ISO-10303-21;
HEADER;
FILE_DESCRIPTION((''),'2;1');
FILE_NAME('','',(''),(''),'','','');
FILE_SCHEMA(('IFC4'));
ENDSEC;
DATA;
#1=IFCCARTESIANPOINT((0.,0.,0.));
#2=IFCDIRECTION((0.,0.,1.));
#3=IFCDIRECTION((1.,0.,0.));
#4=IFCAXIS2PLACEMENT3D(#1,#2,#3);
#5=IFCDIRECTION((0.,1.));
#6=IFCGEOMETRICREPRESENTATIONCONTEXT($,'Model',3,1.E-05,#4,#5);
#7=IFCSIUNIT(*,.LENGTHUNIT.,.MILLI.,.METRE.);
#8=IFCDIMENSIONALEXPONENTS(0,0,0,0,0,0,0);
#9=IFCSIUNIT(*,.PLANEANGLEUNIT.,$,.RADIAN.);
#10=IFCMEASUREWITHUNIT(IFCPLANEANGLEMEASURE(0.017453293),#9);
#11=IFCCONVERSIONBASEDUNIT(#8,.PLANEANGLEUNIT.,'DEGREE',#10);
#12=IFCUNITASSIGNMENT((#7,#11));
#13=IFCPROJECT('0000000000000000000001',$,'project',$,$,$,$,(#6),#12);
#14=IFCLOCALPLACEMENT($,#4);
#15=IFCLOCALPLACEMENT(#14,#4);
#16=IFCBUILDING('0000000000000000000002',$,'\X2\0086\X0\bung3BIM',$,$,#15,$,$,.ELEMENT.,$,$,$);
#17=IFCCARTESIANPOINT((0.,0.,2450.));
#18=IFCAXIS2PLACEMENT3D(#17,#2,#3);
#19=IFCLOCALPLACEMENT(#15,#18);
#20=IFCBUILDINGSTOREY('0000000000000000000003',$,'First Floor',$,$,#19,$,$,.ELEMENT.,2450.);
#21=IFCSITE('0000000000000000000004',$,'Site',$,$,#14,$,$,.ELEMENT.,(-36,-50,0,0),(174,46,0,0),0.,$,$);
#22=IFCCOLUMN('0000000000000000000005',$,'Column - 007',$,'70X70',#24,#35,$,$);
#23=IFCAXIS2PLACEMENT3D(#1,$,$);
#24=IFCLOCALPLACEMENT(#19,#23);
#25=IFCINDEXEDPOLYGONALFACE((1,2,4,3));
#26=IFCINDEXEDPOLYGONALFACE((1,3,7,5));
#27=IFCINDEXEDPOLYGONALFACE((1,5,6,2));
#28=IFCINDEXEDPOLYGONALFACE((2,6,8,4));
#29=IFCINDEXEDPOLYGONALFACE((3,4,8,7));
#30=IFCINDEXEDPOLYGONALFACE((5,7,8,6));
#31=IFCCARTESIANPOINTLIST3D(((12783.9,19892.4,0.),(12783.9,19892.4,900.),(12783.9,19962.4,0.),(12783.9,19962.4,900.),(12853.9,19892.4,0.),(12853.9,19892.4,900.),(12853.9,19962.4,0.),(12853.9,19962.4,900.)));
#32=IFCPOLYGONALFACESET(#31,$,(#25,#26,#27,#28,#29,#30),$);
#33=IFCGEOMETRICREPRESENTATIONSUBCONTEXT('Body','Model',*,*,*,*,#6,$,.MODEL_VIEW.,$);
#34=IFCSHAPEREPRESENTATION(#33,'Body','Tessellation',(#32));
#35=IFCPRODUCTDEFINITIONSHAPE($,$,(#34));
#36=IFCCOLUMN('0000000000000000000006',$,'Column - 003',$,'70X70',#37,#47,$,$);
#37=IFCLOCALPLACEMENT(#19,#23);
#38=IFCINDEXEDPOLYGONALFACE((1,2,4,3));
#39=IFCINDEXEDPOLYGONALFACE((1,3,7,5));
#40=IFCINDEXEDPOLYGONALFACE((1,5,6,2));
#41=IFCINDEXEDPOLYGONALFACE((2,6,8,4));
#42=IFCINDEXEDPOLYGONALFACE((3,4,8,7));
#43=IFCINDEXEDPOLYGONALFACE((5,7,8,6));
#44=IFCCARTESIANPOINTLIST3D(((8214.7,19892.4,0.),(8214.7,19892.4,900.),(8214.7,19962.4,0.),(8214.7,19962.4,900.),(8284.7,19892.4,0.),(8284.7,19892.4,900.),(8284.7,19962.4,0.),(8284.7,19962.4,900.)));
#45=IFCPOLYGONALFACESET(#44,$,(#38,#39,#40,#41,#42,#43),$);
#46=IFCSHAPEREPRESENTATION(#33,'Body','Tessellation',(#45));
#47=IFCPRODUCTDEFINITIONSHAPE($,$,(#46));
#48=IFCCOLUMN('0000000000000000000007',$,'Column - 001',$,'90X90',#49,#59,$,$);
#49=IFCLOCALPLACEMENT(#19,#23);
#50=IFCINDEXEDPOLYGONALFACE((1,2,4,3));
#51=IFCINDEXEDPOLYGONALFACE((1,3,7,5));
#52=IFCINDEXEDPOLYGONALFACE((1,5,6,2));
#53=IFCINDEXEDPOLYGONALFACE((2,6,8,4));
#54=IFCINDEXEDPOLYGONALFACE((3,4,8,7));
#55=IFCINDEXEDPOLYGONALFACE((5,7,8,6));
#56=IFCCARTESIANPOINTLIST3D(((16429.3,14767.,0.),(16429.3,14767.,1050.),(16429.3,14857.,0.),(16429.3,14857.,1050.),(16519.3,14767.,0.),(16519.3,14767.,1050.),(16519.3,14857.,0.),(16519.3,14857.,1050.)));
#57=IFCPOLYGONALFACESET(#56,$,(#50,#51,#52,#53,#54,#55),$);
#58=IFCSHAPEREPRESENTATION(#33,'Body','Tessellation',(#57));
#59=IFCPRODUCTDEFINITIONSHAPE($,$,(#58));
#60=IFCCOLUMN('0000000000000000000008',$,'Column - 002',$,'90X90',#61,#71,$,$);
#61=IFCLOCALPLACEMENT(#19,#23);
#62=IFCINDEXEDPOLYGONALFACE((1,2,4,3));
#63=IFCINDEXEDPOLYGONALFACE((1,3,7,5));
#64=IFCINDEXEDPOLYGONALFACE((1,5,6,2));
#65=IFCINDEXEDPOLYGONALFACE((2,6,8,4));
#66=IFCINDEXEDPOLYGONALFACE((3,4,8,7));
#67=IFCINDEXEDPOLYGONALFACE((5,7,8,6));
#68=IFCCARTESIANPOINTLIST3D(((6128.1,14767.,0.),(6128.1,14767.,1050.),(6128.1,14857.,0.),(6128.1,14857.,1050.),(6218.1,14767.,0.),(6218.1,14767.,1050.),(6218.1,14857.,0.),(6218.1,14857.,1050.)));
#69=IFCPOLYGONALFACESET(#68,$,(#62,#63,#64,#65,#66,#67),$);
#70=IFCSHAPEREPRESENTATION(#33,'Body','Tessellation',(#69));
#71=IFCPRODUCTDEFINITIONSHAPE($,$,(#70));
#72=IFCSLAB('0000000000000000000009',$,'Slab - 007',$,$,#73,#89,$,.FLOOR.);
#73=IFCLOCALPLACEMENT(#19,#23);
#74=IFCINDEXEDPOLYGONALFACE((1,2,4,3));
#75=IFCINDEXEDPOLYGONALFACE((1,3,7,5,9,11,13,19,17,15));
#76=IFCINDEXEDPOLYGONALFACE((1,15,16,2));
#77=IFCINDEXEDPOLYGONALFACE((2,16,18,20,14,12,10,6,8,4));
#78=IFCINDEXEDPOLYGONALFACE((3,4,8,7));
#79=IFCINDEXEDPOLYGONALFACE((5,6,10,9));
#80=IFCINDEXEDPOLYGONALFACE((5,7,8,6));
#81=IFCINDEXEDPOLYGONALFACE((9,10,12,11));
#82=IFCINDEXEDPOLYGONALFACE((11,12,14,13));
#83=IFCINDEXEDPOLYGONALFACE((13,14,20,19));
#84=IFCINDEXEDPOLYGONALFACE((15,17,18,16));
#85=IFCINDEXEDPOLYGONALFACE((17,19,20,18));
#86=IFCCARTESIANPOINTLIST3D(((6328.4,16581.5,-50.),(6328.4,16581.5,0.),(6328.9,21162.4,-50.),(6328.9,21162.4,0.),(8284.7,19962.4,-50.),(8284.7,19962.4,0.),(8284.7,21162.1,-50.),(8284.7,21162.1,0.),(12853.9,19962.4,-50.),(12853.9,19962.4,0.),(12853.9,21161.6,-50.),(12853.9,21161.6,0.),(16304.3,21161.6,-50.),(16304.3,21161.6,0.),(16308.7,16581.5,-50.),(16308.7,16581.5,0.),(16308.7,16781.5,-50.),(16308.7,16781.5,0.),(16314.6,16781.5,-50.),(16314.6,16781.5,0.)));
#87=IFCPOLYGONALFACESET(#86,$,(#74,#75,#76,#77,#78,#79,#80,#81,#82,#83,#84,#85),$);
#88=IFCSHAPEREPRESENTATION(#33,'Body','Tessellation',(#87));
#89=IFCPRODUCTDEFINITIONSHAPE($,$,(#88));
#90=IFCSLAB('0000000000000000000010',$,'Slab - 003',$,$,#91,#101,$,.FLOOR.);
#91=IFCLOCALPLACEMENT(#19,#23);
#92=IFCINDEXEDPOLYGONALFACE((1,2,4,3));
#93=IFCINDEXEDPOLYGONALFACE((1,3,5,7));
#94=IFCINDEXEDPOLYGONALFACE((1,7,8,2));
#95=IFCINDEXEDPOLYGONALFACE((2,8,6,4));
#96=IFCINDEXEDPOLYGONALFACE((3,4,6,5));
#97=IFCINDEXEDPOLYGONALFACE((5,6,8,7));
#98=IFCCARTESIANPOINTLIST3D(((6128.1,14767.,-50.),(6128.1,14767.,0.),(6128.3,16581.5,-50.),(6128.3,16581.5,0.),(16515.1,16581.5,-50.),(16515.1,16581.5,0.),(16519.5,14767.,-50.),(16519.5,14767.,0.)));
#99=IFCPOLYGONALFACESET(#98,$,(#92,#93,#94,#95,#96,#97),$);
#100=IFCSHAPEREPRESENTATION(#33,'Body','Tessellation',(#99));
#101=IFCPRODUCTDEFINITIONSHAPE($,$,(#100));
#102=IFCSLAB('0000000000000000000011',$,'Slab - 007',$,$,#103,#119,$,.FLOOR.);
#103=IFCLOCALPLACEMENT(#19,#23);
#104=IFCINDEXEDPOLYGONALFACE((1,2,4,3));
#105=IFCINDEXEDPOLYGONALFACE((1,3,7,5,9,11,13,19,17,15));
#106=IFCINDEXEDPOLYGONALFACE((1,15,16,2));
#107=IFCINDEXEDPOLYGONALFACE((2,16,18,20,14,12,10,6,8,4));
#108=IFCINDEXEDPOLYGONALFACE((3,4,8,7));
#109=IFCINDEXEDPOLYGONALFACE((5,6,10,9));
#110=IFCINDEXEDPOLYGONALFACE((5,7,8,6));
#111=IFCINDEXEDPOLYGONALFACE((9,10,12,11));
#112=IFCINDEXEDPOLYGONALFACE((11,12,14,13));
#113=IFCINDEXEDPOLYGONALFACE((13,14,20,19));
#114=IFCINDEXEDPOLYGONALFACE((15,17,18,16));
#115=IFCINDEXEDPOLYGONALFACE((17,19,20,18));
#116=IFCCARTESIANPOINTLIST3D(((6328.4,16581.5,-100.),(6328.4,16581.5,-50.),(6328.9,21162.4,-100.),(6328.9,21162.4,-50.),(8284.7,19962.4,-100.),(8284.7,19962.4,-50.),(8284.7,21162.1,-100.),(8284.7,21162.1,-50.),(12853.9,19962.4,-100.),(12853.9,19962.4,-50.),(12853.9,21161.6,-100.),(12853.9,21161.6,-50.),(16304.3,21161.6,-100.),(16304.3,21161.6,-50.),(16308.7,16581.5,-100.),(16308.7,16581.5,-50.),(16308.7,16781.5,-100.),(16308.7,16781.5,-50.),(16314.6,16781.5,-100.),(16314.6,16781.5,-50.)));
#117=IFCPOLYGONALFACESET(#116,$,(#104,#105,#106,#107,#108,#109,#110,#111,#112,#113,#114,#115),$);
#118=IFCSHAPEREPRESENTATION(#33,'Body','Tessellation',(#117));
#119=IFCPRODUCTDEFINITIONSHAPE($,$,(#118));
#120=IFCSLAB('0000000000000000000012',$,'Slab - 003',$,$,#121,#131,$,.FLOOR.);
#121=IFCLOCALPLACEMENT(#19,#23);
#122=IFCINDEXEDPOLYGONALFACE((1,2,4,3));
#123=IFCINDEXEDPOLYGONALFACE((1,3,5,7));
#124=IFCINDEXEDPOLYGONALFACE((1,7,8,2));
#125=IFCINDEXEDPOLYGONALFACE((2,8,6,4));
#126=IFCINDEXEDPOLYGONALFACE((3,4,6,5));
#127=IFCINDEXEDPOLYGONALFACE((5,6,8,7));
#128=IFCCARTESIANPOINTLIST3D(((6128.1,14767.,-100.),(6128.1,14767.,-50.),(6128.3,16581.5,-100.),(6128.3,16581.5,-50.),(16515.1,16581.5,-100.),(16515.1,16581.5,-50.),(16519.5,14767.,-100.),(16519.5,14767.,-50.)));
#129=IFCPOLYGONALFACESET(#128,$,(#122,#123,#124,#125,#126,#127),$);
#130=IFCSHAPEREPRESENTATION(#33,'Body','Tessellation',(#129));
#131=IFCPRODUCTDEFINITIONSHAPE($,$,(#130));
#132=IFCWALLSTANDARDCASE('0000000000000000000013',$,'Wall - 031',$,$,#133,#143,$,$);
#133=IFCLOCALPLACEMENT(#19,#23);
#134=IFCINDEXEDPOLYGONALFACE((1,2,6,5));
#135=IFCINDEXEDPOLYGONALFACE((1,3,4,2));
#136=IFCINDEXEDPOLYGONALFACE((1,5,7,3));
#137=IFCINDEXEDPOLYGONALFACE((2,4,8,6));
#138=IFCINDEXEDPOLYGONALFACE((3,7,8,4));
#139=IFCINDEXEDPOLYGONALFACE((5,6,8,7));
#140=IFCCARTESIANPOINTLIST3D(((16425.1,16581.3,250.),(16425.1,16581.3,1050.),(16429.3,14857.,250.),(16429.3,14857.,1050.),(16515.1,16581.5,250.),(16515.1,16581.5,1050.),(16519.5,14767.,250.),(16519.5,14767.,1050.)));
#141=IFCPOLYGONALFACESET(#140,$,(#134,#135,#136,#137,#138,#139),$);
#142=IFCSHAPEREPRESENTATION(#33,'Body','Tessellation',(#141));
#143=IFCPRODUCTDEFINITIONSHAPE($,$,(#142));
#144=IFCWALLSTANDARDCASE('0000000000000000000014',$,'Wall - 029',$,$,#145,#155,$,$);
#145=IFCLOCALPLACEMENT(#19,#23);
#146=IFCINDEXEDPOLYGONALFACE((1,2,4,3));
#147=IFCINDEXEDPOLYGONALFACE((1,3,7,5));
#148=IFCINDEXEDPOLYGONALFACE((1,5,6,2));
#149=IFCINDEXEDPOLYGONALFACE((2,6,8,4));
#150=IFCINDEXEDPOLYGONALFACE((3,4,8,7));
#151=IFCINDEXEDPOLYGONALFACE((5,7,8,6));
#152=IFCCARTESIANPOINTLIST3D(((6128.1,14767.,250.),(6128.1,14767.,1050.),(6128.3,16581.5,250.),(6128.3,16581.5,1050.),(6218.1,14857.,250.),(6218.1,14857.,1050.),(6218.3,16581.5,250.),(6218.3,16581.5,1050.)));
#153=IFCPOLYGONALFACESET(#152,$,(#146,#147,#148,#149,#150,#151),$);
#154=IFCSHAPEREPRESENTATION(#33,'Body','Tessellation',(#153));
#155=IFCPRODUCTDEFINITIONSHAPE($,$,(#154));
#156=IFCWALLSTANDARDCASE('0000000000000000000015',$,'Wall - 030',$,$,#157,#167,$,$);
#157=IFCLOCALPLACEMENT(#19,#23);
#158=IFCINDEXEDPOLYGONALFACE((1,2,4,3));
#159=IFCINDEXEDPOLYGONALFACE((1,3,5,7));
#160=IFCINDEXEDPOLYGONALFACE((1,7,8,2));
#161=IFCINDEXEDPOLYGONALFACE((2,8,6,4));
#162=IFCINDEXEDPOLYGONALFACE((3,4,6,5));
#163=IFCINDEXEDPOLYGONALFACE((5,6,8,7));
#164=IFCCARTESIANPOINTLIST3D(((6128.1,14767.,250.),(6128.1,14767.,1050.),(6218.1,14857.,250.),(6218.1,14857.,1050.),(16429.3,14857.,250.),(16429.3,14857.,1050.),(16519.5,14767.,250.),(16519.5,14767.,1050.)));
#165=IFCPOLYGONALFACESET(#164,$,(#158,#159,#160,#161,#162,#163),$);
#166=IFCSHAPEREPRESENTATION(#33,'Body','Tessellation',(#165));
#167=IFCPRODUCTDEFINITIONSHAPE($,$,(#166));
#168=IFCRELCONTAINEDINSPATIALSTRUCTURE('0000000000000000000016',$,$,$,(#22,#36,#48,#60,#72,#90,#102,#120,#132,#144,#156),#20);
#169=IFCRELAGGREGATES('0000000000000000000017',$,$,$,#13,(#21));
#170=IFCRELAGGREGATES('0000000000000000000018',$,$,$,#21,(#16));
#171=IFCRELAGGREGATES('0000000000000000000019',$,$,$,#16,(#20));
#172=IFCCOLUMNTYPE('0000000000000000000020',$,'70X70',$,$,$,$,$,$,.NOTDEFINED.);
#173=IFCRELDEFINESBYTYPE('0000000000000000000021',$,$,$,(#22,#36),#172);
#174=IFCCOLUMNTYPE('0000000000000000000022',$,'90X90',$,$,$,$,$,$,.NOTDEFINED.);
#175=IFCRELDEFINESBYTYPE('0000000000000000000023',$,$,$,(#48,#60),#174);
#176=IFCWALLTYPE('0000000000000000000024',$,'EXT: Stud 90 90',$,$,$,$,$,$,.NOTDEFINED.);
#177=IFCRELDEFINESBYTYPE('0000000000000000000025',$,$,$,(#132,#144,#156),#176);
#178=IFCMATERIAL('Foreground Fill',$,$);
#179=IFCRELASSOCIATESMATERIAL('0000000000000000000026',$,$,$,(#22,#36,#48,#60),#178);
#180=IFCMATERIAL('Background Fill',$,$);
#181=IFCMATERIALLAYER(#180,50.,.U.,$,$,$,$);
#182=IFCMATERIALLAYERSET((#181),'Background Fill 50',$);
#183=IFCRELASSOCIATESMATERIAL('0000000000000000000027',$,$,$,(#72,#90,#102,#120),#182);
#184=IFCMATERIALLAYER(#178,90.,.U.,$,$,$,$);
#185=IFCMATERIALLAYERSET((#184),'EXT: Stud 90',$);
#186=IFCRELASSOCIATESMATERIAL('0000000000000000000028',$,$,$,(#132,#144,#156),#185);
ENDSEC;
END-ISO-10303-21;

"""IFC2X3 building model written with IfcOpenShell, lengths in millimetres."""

from ifc_helpers import new_model, entity, si_unit, converted_unit, direction, frame, origin_with_axes, origin_2d_with_axis, place, context, subcontext, project, spatial, polyline, rectangle, outline, extrude, material, layer, layer_set, layer_usage, type_object, element, save


model = new_model("IFC2X3")

# Units and contexts
model_context = context("Model", 3, precision=1e-05, world=origin_with_axes(), true_north=direction((0.0, 1.0)))
body_context = subcontext(model_context, "Body", "Model", "MODEL_VIEW")
ifc_project = project(units=[si_unit("LENGTHUNIT", "METRE", prefix="MILLI"), converted_unit("PLANEANGLEUNIT", "DEGREE", entity("IfcPlaneAngleMeasure", 0.017453293), si_unit("PLANEANGLEUNIT", "RADIAN"), dimensions=[0, 0, 0, 0, 0, 0, 0])], contexts=[model_context])

# Site, building, storey
site_placement = place(None, origin_with_axes())
site = spatial("IfcSite", under=ifc_project, at=site_placement, Name="Site", CompositionType="ELEMENT", RefLatitude=(-36, -50, 0, 0), RefLongitude=(174, 46, 0, 0), RefElevation=0.0)
building_placement = place(site_placement, origin_with_axes())
building = spatial("IfcBuilding", under=site, at=building_placement, Name="\u0086bung3BIM", CompositionType="ELEMENT")
storey_placement = place(building_placement, frame((0.0, 0.0, 2450.0), z_axis=(0.0, 0.0, 1.0), x_axis=(1.0, 0.0, 0.0)))
storey = spatial("IfcBuildingStorey", under=building, at=storey_placement, Name="First Floor", CompositionType="ELEMENT", Elevation=2450.0)

# Columns
ifc_material_1 = material(Name="Foreground Fill")
column_type_1 = type_object("IfcColumnType", Name="70X70", PredefinedType="NOTDEFINED")
for number, where, z_axis, x_axis, name in (
    (1, (12818.9, 19927.4, 0.0), (0.0, 0.0, 1.0), (1.0, 0.0, 0.0), "Column - 007"),
    (2, (8249.7, 19927.4, 0.0), (0.0, 0.0, 1.0), (1.0, 0.0, 0.0), "Column - 003"),
):
    element("IfcColumn", number, at=place(storey_placement, frame(where, z_axis=z_axis, x_axis=x_axis)), inside=storey, type_object=column_type_1, material=ifc_material_1, Name=name, ObjectType="70X70", context=body_context, shape_type="SweptSolid", body=[
        extrude(rectangle(XDim=70.0, YDim=70.0, at=origin_2d_with_axis()), origin_with_axes(), (0.0, 0.0, 1.0), 900.0),
    ])
column_type_2 = type_object("IfcColumnType", Name="90X90", PredefinedType="NOTDEFINED")
for number, where, z_axis, x_axis, name in (
    (3, (16474.3, 14812.0, 0.0), (0.0, 0.0, 1.0), (-1.0, 0.0, 0.0), "Column - 001"),
    (4, (6173.1, 14812.0, 0.0), (0.0, 0.0, 1.0), (-1.0, 0.0, 0.0), "Column - 002"),
):
    element("IfcColumn", number, at=place(storey_placement, frame(where, z_axis=z_axis, x_axis=x_axis)), inside=storey, type_object=column_type_2, material=ifc_material_1, Name=name, ObjectType="90X90", context=body_context, shape_type="SweptSolid", body=[
        extrude(rectangle(XDim=90.0, YDim=90.0, at=origin_2d_with_axis()), origin_with_axes(), (0.0, 0.0, 1.0), 1050.0),
    ])

# Slabs
ifc_material_2 = material(Name="Background Fill")
ifc_layer_1 = layer(ifc_material_2, 50.0, ventilated="UNKNOWN")
ifc_layer_set_1 = layer_set([ifc_layer_1], Name="Background Fill 50")
ifc_layer_usage_1 = layer_usage(ifc_layer_set_1, "AXIS3", "NEGATIVE", 50.0)
slab_1_placement = place(storey_placement, frame((16314.6, 16781.5, -50.0), z_axis=(0.0, 0.0, 1.0), x_axis=(1.0, 0.0, 0.0)))
element("IfcSlab", 5, at=slab_1_placement, inside=storey, material=ifc_layer_usage_1, Name="Slab - 007", PredefinedType="FLOOR", context=body_context, shape_type="SweptSolid", body=[
    extrude(outline(polyline([(0.0, 0.0), (-10.4, 4380.1), (-3460.7, 4380.1), (-3460.7, 3180.9), (-8029.9, 3180.9), (-8029.9, 4380.6), (-9985.7, 4380.9), (-9986.3, -200.0), (-5.9, -200.0), (-5.9, 0.0), (0.0, 0.0)])), origin_with_axes(), (0.0, 0.0, 1.0), 50.0),
])
ifc_layer_usage_2 = layer_usage(ifc_layer_set_1, "AXIS3", "NEGATIVE", 50.0)
slab_2_placement = place(storey_placement, frame((6128.1, 14767.0, -50.0), z_axis=(0.0, 0.0, 1.0), x_axis=(1.0, 0.0, 0.0)))
element("IfcSlab", 6, at=slab_2_placement, inside=storey, material=ifc_layer_usage_2, Name="Slab - 003", PredefinedType="FLOOR", context=body_context, shape_type="SweptSolid", body=[
    extrude(outline(polyline([(0.0, 0.0), (10391.4, 0.0), (10387.0, 1814.5), (0.2, 1814.5), (0.0, 0.0)])), origin_with_axes(), (0.0, 0.0, 1.0), 50.0),
])
ifc_layer_usage_3 = layer_usage(ifc_layer_set_1, "AXIS3", "NEGATIVE", 50.0)
slab_3_placement = place(storey_placement, frame((16314.6, 16781.5, -100.0), z_axis=(0.0, 0.0, 1.0), x_axis=(1.0, 0.0, 0.0)))
element("IfcSlab", 7, at=slab_3_placement, inside=storey, material=ifc_layer_usage_3, Name="Slab - 007", PredefinedType="FLOOR", context=body_context, shape_type="SweptSolid", body=[
    extrude(outline(polyline([(0.0, 0.0), (-10.4, 4380.1), (-3460.7, 4380.1), (-3460.7, 3180.9), (-8029.9, 3180.9), (-8029.9, 4380.6), (-9985.7, 4380.9), (-9986.3, -200.0), (-5.9, -200.0), (-5.9, 0.0), (0.0, 0.0)])), origin_with_axes(), (0.0, 0.0, 1.0), 50.0),
])
ifc_layer_usage_4 = layer_usage(ifc_layer_set_1, "AXIS3", "NEGATIVE", 50.0)
slab_4_placement = place(storey_placement, frame((6128.1, 14767.0, -100.0), z_axis=(0.0, 0.0, 1.0), x_axis=(1.0, 0.0, 0.0)))
element("IfcSlab", 8, at=slab_4_placement, inside=storey, material=ifc_layer_usage_4, Name="Slab - 003", PredefinedType="FLOOR", context=body_context, shape_type="SweptSolid", body=[
    extrude(outline(polyline([(0.0, 0.0), (10391.4, 0.0), (10387.0, 1814.5), (0.2, 1814.5), (0.0, 0.0)])), origin_with_axes(), (0.0, 0.0, 1.0), 50.0),
])

# Walls
ifc_layer_2 = layer(ifc_material_1, 90.0, ventilated="UNKNOWN")
ifc_layer_set_2 = layer_set([ifc_layer_2], Name="EXT: Stud 90")
ifc_layer_usage_5 = layer_usage(ifc_layer_set_2, "AXIS2", "POSITIVE", 0.0)
wall_type_1 = type_object("IfcWallType", Name="EXT: Stud 90 90", PredefinedType="NOTDEFINED")
wall_1_placement = place(storey_placement, frame((16519.5, 14767.0, 250.0), z_axis=(0.0, 0.0, 1.0), x_axis=(-0.00241, 0.999997, 0.0)))
element("IfcWallStandardCase", 9, at=wall_1_placement, inside=storey, type_object=wall_type_1, material=ifc_layer_usage_5, Name="Wall - 031", context=body_context, shape_type="SweptSolid", body=[
    extrude(outline(polyline([(0.0, 0.0), (1814.5, 0.0), (1814.5, 90.0), (90.2, 90.0), (0.0, 0.0)])), origin_with_axes(), (0.0, 0.0, 1.0), 800.0),
])
ifc_layer_usage_6 = layer_usage(ifc_layer_set_2, "AXIS2", "POSITIVE", 0.0)
wall_2_placement = place(storey_placement, frame((6128.3, 16581.5, 250.0), z_axis=(0.0, 0.0, 1.0), x_axis=(-0.000123, -1.0, 0.0)))
element("IfcWallStandardCase", 10, at=wall_2_placement, inside=storey, type_object=wall_type_1, material=ifc_layer_usage_6, Name="Wall - 029", context=body_context, shape_type="SweptSolid", body=[
    extrude(outline(polyline([(0.0, 0.0), (1814.5, 0.0), (1724.5, 90.0), (0.0, 90.0), (0.0, 0.0)])), origin_with_axes(), (0.0, 0.0, 1.0), 800.0),
])
ifc_layer_usage_7 = layer_usage(ifc_layer_set_2, "AXIS2", "POSITIVE", 0.0)
wall_3_placement = place(storey_placement, frame((6128.1, 14767.0, 250.0), z_axis=(0.0, 0.0, 1.0), x_axis=(1.0, 0.0, 0.0)))
element("IfcWallStandardCase", 11, at=wall_3_placement, inside=storey, type_object=wall_type_1, material=ifc_layer_usage_7, Name="Wall - 030", context=body_context, shape_type="SweptSolid", body=[
    extrude(outline(polyline([(0.0, 0.0), (10391.4, 0.0), (10301.1, 90.0), (90.0, 90.0), (0.0, 0.0)])), origin_with_axes(), (0.0, 0.0, 1.0), 800.0),
])

save(model, "model.ifc")
